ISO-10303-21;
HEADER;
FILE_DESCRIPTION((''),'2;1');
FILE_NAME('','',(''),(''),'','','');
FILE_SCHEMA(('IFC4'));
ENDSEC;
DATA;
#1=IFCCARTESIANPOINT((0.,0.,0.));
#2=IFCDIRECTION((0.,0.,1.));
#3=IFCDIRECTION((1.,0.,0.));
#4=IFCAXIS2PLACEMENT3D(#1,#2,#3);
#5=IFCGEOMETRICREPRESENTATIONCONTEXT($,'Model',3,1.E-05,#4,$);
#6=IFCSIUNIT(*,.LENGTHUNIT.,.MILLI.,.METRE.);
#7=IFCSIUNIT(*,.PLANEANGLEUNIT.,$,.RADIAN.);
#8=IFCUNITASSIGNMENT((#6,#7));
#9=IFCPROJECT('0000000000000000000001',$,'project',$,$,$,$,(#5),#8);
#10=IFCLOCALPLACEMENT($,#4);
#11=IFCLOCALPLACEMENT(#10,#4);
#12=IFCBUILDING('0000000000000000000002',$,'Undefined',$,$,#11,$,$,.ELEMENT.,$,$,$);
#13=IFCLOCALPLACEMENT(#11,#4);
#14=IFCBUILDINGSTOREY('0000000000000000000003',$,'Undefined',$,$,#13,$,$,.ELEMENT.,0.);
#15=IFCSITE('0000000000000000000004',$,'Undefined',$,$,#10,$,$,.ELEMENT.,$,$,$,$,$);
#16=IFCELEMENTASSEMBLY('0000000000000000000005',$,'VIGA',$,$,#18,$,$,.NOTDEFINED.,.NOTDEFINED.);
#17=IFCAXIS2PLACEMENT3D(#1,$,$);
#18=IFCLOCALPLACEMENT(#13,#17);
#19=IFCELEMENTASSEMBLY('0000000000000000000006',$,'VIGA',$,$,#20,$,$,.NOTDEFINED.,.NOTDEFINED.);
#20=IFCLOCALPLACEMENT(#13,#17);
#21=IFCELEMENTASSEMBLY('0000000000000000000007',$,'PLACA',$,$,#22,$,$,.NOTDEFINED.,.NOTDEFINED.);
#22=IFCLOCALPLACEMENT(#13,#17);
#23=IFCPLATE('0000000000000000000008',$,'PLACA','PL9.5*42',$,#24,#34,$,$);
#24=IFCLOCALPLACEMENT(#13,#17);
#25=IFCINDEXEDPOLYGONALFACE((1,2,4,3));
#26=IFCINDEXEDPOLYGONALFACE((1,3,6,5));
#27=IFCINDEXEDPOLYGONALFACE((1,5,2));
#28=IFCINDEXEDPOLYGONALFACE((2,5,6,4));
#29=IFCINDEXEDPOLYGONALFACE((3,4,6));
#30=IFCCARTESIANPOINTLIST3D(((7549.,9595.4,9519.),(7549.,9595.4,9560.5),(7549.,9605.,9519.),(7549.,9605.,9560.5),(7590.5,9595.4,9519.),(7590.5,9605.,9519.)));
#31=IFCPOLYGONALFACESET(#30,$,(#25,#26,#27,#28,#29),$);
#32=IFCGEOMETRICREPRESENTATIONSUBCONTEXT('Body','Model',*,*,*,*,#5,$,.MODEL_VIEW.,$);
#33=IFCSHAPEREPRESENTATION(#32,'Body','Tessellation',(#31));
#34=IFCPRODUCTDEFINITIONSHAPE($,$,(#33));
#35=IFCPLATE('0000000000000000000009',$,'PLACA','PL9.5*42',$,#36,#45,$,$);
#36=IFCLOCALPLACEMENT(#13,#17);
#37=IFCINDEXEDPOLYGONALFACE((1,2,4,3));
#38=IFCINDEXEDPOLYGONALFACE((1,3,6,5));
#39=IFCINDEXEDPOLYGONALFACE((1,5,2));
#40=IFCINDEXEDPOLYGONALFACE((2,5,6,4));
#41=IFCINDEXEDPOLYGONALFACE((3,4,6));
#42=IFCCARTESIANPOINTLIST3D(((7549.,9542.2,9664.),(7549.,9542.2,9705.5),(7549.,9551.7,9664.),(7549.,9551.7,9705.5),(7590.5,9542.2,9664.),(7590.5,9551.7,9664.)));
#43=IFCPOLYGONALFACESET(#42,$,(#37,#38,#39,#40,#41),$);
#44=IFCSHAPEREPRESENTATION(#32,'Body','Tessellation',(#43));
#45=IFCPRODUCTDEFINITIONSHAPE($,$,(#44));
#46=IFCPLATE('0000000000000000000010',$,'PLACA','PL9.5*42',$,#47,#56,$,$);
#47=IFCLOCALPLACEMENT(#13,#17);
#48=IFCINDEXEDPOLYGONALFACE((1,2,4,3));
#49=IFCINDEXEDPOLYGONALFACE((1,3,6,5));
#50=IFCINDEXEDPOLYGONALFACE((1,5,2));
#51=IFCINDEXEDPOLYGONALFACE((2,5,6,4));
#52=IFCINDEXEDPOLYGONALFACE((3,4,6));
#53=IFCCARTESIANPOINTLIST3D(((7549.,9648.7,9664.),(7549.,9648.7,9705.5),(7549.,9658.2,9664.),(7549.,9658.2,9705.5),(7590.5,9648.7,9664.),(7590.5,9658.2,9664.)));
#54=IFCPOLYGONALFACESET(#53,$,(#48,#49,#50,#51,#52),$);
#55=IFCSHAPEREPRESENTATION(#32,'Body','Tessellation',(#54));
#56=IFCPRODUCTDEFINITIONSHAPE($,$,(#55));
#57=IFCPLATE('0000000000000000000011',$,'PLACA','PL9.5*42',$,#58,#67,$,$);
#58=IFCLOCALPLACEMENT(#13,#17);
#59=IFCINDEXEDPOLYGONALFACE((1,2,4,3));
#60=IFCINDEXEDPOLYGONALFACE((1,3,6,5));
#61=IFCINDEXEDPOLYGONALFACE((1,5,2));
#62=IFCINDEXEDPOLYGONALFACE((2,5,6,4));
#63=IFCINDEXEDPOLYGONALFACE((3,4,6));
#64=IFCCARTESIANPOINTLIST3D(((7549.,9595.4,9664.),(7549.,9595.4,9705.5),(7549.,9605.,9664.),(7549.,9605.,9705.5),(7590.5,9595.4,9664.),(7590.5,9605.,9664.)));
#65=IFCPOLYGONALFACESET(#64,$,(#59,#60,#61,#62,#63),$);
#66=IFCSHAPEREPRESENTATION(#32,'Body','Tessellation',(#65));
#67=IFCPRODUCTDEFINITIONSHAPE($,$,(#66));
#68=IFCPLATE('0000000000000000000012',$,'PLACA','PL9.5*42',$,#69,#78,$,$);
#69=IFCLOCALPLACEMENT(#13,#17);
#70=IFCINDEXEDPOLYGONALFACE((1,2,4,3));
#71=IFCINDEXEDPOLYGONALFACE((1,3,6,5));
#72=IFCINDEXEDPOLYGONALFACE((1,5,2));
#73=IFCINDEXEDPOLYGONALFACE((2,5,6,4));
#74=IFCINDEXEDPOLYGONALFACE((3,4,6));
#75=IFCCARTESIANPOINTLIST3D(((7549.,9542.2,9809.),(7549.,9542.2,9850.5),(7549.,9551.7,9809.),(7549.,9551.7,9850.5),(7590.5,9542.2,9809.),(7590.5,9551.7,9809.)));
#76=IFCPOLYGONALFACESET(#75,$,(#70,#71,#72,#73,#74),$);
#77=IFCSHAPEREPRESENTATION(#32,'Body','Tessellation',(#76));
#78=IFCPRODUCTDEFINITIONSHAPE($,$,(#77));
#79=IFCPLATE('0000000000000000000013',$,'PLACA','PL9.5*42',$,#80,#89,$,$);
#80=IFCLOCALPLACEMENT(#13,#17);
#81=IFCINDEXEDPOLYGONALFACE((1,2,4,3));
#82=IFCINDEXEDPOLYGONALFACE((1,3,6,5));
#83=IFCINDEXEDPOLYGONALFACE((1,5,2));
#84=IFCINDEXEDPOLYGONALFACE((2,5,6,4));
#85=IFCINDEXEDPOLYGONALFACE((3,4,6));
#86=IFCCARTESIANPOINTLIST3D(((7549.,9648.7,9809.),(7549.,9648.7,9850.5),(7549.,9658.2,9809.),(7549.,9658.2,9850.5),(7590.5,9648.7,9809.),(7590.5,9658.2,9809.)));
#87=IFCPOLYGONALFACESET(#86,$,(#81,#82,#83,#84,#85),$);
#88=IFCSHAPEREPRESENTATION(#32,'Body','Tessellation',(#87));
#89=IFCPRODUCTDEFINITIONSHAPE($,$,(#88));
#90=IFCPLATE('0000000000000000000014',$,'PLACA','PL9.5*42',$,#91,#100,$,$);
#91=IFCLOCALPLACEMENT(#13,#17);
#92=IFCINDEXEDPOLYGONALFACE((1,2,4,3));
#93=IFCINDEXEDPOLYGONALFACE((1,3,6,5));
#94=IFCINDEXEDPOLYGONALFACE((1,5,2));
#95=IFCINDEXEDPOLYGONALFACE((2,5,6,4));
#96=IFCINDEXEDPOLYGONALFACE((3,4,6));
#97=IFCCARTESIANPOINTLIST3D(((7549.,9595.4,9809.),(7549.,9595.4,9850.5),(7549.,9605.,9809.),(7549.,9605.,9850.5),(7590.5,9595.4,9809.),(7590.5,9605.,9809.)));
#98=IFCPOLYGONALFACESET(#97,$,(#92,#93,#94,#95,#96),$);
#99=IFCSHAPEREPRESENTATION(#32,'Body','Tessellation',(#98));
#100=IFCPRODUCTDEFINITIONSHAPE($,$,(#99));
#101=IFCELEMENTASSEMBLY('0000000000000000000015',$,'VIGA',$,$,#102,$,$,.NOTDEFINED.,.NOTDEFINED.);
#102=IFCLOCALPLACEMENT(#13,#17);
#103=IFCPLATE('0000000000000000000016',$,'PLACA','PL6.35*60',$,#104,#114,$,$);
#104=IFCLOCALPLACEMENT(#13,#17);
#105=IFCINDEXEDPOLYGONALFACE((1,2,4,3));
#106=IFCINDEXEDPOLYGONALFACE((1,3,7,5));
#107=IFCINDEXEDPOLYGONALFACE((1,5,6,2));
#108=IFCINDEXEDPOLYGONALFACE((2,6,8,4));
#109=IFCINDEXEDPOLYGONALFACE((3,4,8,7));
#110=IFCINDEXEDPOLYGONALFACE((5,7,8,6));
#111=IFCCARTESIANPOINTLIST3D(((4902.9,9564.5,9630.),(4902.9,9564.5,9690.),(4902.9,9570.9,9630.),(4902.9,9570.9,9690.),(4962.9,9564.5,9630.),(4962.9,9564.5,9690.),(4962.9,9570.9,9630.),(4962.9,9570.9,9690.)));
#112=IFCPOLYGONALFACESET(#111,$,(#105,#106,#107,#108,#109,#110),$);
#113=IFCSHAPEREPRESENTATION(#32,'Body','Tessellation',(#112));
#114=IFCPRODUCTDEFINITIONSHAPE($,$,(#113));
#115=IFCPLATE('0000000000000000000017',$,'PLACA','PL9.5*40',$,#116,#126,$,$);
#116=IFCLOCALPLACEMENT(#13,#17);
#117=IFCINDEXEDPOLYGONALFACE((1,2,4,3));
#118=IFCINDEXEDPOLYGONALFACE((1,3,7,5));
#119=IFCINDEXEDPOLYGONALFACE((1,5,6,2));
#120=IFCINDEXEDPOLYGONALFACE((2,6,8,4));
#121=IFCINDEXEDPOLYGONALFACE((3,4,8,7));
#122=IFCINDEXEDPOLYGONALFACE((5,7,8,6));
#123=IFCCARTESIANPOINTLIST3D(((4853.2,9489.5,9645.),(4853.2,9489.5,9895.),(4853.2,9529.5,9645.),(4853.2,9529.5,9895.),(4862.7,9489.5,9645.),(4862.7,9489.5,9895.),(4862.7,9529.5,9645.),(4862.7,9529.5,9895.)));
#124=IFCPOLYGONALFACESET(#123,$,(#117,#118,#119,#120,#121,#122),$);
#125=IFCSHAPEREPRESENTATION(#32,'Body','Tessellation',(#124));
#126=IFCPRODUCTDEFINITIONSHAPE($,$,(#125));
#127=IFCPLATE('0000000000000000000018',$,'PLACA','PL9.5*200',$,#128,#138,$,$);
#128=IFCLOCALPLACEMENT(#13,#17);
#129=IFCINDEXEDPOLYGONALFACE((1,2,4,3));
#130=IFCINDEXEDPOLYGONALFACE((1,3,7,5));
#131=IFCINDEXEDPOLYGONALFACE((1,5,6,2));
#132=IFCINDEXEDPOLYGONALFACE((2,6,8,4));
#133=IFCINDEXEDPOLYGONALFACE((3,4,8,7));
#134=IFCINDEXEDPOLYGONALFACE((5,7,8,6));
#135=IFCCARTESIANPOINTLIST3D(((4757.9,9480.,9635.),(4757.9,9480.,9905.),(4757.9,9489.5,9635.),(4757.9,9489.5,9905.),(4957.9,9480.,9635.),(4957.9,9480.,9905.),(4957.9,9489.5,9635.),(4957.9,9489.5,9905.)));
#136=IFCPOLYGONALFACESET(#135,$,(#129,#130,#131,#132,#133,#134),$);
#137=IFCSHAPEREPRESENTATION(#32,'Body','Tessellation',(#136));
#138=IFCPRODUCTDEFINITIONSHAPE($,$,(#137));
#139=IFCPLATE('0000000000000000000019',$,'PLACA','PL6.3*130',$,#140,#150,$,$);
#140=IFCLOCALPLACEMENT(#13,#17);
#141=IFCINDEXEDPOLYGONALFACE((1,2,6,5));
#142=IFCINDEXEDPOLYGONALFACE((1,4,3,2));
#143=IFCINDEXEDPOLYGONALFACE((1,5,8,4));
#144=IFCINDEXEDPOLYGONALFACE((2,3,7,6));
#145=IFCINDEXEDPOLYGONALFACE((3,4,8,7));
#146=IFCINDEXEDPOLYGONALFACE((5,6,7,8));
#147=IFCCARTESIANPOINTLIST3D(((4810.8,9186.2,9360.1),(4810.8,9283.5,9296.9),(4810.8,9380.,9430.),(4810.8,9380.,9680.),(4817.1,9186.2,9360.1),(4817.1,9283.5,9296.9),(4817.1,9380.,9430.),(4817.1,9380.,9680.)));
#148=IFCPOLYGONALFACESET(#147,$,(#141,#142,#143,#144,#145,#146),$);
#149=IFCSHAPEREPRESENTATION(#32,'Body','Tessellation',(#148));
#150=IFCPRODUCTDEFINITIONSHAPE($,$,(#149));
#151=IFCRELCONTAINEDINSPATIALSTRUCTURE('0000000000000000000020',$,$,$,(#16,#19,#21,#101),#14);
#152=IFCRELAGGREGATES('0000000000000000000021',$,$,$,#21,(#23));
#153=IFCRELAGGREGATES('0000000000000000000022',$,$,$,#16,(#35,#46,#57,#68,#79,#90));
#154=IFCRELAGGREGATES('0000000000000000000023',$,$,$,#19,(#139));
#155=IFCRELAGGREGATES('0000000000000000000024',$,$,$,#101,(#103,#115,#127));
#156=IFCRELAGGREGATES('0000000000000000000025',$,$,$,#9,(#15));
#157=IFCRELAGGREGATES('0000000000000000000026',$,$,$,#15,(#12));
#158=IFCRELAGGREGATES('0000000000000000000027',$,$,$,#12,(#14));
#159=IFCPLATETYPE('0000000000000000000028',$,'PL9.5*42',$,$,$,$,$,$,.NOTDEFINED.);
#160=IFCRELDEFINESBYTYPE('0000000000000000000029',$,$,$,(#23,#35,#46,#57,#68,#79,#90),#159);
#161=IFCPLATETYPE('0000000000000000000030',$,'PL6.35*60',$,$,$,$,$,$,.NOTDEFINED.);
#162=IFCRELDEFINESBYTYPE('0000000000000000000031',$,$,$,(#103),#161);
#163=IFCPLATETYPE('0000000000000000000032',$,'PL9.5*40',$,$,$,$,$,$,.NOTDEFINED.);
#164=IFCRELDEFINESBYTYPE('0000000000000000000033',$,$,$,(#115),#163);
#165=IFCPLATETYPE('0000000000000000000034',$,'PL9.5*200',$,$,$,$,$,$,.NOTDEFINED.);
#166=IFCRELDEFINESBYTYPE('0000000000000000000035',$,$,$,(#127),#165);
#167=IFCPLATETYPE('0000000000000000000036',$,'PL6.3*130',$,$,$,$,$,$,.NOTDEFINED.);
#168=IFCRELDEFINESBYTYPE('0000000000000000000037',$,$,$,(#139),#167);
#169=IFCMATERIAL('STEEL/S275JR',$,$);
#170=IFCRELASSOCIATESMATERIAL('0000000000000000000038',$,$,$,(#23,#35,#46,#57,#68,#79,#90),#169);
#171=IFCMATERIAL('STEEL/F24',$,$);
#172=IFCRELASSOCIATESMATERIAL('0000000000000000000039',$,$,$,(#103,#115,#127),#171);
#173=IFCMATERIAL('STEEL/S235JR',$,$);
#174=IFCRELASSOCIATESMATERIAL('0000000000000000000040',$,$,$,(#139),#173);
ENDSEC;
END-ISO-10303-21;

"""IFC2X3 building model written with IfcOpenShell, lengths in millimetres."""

from ifc_helpers import new_model, si_unit, frame, origin_with_axes, place, context, subcontext, project, spatial, polyline, outline, extrude, material, type_object, element, aggregate, save


model = new_model("IFC2X3")

# Units and contexts
model_context = context("Model", 3, precision=1e-05, world=origin_with_axes())
body_context = subcontext(model_context, "Body", "Model", "MODEL_VIEW")
ifc_project = project(units=[si_unit("LENGTHUNIT", "METRE", prefix="MILLI"), si_unit("PLANEANGLEUNIT", "RADIAN")], contexts=[model_context])

# Site, building, storey
site_placement = place(None, origin_with_axes())
site = spatial("IfcSite", under=ifc_project, at=site_placement, Name="Undefined", CompositionType="ELEMENT")
building_placement = place(site_placement, origin_with_axes())
building = spatial("IfcBuilding", under=site, at=building_placement, Name="Undefined", CompositionType="ELEMENT")
storey_placement = place(building_placement, origin_with_axes())
storey = spatial("IfcBuildingStorey", under=building, at=storey_placement, Name="Undefined", CompositionType="ELEMENT", Elevation=0.0)

# Element assembly
assembly_1_placement = place(storey_placement, origin_with_axes())
assembly_1 = element("IfcElementAssembly", 1, at=assembly_1_placement, inside=storey, Name="VIGA", AssemblyPlace="NOTDEFINED", PredefinedType="NOTDEFINED")
ifc_material_1 = material(Name="STEEL/S275JR")

# Element assembly
ifc_material_2 = material(Name="STEEL/S235JR")
assembly_2_placement = place(storey_placement, origin_with_axes())
assembly_2 = element("IfcElementAssembly", 2, at=assembly_2_placement, inside=storey, Name="VIGA", AssemblyPlace="NOTDEFINED", PredefinedType="NOTDEFINED")

# Element assembly, plate
plate_type_1 = type_object("IfcPlateType", Name="PL9.5*42", PredefinedType="NOTDEFINED")
assembly_3_placement = place(storey_placement, origin_with_axes())
assembly_3 = element("IfcElementAssembly", 3, at=assembly_3_placement, inside=storey, Name="PLACA", AssemblyPlace="NOTDEFINED", PredefinedType="NOTDEFINED")
plate_1_placement = place(assembly_3_placement, frame((7549.0, 9600.2, 9519.0), z_axis=(0.0, 1.0, 0.0), x_axis=(0.0, 0.0, 1.0)))
plate_1 = element("IfcPlate", 4, at=plate_1_placement, type_object=plate_type_1, material=ifc_material_1, Name="PLACA", Description="PL9.5*42", context=body_context, shape_type="SweptSolid", body=[
    extrude(outline(polyline([(0.0, 0.0), (41.5, 0.0), (0.0, 41.5), (0.0, 0.0)])), frame((0.0, 0.0, -4.7), z_axis=(0.0, 0.0, 1.0), x_axis=(1.0, 0.0, 0.0)), (0.0, 0.0, 1.0), 9.5),
])
aggregate(assembly_3, [plate_1])

# Plates
plate_2_placement = place(assembly_1_placement, frame((7549.0, 9547.0, 9664.0), z_axis=(0.0, 1.0, 0.0), x_axis=(0.0, 0.0, 1.0)))
plate_2 = element("IfcPlate", 5, at=plate_2_placement, type_object=plate_type_1, material=ifc_material_1, Name="PLACA", Description="PL9.5*42", context=body_context, shape_type="SweptSolid", body=[
    extrude(outline(polyline([(0.0, 0.0), (41.5, 0.0), (0.0, 41.5), (0.0, 0.0)])), frame((0.0, 0.0, -4.7), z_axis=(0.0, 0.0, 1.0), x_axis=(1.0, 0.0, 0.0)), (0.0, 0.0, 1.0), 9.5),
])
plate_3_placement = place(assembly_1_placement, frame((7549.0, 9653.5, 9664.0), z_axis=(0.0, 1.0, 0.0), x_axis=(0.0, 0.0, 1.0)))
plate_3 = element("IfcPlate", 6, at=plate_3_placement, type_object=plate_type_1, material=ifc_material_1, Name="PLACA", Description="PL9.5*42", context=body_context, shape_type="SweptSolid", body=[
    extrude(outline(polyline([(0.0, 0.0), (41.5, 0.0), (0.0, 41.5), (0.0, 0.0)])), frame((0.0, 0.0, -4.7), z_axis=(0.0, 0.0, 1.0), x_axis=(1.0, 0.0, 0.0)), (0.0, 0.0, 1.0), 9.5),
])
plate_4_placement = place(assembly_1_placement, frame((7549.0, 9600.2, 9664.0), z_axis=(0.0, 1.0, 0.0), x_axis=(0.0, 0.0, 1.0)))
plate_4 = element("IfcPlate", 7, at=plate_4_placement, type_object=plate_type_1, material=ifc_material_1, Name="PLACA", Description="PL9.5*42", context=body_context, shape_type="SweptSolid", body=[
    extrude(outline(polyline([(0.0, 0.0), (41.5, 0.0), (0.0, 41.5), (0.0, 0.0)])), frame((0.0, 0.0, -4.7), z_axis=(0.0, 0.0, 1.0), x_axis=(1.0, 0.0, 0.0)), (0.0, 0.0, 1.0), 9.5),
])
plate_5_placement = place(assembly_1_placement, frame((7549.0, 9547.0, 9809.0), z_axis=(0.0, 1.0, 0.0), x_axis=(0.0, 0.0, 1.0)))
plate_5 = element("IfcPlate", 8, at=plate_5_placement, type_object=plate_type_1, material=ifc_material_1, Name="PLACA", Description="PL9.5*42", context=body_context, shape_type="SweptSolid", body=[
    extrude(outline(polyline([(0.0, 0.0), (41.5, 0.0), (0.0, 41.5), (0.0, 0.0)])), frame((0.0, 0.0, -4.7), z_axis=(0.0, 0.0, 1.0), x_axis=(1.0, 0.0, 0.0)), (0.0, 0.0, 1.0), 9.5),
])
plate_6_placement = place(assembly_1_placement, frame((7549.0, 9653.5, 9809.0), z_axis=(0.0, 1.0, 0.0), x_axis=(0.0, 0.0, 1.0)))
plate_6 = element("IfcPlate", 9, at=plate_6_placement, type_object=plate_type_1, material=ifc_material_1, Name="PLACA", Description="PL9.5*42", context=body_context, shape_type="SweptSolid", body=[
    extrude(outline(polyline([(0.0, 0.0), (41.5, 0.0), (0.0, 41.5), (0.0, 0.0)])), frame((0.0, 0.0, -4.7), z_axis=(0.0, 0.0, 1.0), x_axis=(1.0, 0.0, 0.0)), (0.0, 0.0, 1.0), 9.5),
])
plate_7_placement = place(assembly_1_placement, frame((7549.0, 9600.2, 9809.0), z_axis=(0.0, 1.0, 0.0), x_axis=(0.0, 0.0, 1.0)))
plate_7 = element("IfcPlate", 10, at=plate_7_placement, type_object=plate_type_1, material=ifc_material_1, Name="PLACA", Description="PL9.5*42", context=body_context, shape_type="SweptSolid", body=[
    extrude(outline(polyline([(0.0, 0.0), (41.5, 0.0), (0.0, 41.5), (0.0, 0.0)])), frame((0.0, 0.0, -4.7), z_axis=(0.0, 0.0, 1.0), x_axis=(1.0, 0.0, 0.0)), (0.0, 0.0, 1.0), 9.5),
])
aggregate(assembly_1, [plate_2, plate_3, plate_4, plate_5, plate_6, plate_7])

# Element assembly, plates
assembly_4_placement = place(storey_placement, origin_with_axes())
assembly_4 = element("IfcElementAssembly", 11, at=assembly_4_placement, inside=storey, Name="VIGA", AssemblyPlace="NOTDEFINED", PredefinedType="NOTDEFINED")
ifc_material_3 = material(Name="STEEL/F24")
plate_type_2 = type_object("IfcPlateType", Name="PL6.35*60", PredefinedType="NOTDEFINED")
plate_8_placement = place(assembly_4_placement, frame((4902.9, 9567.7, 9690.0), z_axis=(0.0, 1.0, 0.0), x_axis=(1.0, 0.0, 0.0)))
plate_8 = element("IfcPlate", 12, at=plate_8_placement, type_object=plate_type_2, material=ifc_material_3, Name="PLACA", Description="PL6.35*60", context=body_context, shape_type="SweptSolid", body=[
    extrude(outline(polyline([(0.0, 0.0), (60.0, 0.0), (60.0, 60.0), (0.0, 60.0), (0.0, 0.0)])), frame((0.0, 0.0, -3.2), z_axis=(0.0, 0.0, 1.0), x_axis=(1.0, 0.0, 0.0)), (0.0, 0.0, 1.0), 6.4),
])
plate_type_3 = type_object("IfcPlateType", Name="PL9.5*40", PredefinedType="NOTDEFINED")
plate_9_placement = place(assembly_4_placement, frame((4857.9, 9489.5, 9895.0), z_axis=(1.0, 0.0, 0.0), x_axis=(0.0, 0.0, -1.0)))
plate_9 = element("IfcPlate", 13, at=plate_9_placement, type_object=plate_type_3, material=ifc_material_3, Name="PLACA", Description="PL9.5*40", context=body_context, shape_type="SweptSolid", body=[
    extrude(outline(polyline([(0.0, 0.0), (250.0, 0.0), (250.0, 40.0), (0.0, 40.0), (0.0, 0.0)])), frame((0.0, 0.0, -4.7), z_axis=(0.0, 0.0, 1.0), x_axis=(1.0, 0.0, 0.0)), (0.0, 0.0, 1.0), 9.5),
])
plate_type_4 = type_object("IfcPlateType", Name="PL9.5*200", PredefinedType="NOTDEFINED")
plate_10_placement = place(assembly_4_placement, frame((4757.9, 9484.8, 9905.0), z_axis=(0.0, 1.0, 0.0), x_axis=(1.0, 0.0, 0.0)))
plate_10 = element("IfcPlate", 14, at=plate_10_placement, type_object=plate_type_4, material=ifc_material_3, Name="PLACA", Description="PL9.5*200", context=body_context, shape_type="SweptSolid", body=[
    extrude(outline(polyline([(0.0, 0.0), (200.0, 0.0), (200.0, 270.0), (0.0, 270.0), (0.0, 0.0)])), frame((0.0, 0.0, -4.7), z_axis=(0.0, 0.0, 1.0), x_axis=(1.0, 0.0, 0.0)), (0.0, 0.0, 1.0), 9.5),
])

# Plate
plate_type_5 = type_object("IfcPlateType", Name="PL6.3*130", PredefinedType="NOTDEFINED")
plate_11_placement = place(assembly_2_placement, frame((4813.9, 9380.0, 9680.0), z_axis=(-1.0, 0.0, 0.0), x_axis=(0.0, 0.0, -1.0)))
plate_11 = element("IfcPlate", 15, at=plate_11_placement, type_object=plate_type_5, material=ifc_material_2, Name="PLACA", Description="PL6.3*130", context=body_context, shape_type="SweptSolid", body=[
    extrude(outline(polyline([(0.0, 0.0), (250.0, 0.0), (383.1, 96.5), (319.9, 193.8), (0.0, 0.0)])), frame((0.0, 0.0, -3.1), z_axis=(0.0, 0.0, 1.0), x_axis=(1.0, 0.0, 0.0)), (0.0, 0.0, 1.0), 6.3),
])
aggregate(assembly_2, [plate_11])

aggregate(assembly_4, [plate_8, plate_9, plate_10])

save(model, "model.ifc")
